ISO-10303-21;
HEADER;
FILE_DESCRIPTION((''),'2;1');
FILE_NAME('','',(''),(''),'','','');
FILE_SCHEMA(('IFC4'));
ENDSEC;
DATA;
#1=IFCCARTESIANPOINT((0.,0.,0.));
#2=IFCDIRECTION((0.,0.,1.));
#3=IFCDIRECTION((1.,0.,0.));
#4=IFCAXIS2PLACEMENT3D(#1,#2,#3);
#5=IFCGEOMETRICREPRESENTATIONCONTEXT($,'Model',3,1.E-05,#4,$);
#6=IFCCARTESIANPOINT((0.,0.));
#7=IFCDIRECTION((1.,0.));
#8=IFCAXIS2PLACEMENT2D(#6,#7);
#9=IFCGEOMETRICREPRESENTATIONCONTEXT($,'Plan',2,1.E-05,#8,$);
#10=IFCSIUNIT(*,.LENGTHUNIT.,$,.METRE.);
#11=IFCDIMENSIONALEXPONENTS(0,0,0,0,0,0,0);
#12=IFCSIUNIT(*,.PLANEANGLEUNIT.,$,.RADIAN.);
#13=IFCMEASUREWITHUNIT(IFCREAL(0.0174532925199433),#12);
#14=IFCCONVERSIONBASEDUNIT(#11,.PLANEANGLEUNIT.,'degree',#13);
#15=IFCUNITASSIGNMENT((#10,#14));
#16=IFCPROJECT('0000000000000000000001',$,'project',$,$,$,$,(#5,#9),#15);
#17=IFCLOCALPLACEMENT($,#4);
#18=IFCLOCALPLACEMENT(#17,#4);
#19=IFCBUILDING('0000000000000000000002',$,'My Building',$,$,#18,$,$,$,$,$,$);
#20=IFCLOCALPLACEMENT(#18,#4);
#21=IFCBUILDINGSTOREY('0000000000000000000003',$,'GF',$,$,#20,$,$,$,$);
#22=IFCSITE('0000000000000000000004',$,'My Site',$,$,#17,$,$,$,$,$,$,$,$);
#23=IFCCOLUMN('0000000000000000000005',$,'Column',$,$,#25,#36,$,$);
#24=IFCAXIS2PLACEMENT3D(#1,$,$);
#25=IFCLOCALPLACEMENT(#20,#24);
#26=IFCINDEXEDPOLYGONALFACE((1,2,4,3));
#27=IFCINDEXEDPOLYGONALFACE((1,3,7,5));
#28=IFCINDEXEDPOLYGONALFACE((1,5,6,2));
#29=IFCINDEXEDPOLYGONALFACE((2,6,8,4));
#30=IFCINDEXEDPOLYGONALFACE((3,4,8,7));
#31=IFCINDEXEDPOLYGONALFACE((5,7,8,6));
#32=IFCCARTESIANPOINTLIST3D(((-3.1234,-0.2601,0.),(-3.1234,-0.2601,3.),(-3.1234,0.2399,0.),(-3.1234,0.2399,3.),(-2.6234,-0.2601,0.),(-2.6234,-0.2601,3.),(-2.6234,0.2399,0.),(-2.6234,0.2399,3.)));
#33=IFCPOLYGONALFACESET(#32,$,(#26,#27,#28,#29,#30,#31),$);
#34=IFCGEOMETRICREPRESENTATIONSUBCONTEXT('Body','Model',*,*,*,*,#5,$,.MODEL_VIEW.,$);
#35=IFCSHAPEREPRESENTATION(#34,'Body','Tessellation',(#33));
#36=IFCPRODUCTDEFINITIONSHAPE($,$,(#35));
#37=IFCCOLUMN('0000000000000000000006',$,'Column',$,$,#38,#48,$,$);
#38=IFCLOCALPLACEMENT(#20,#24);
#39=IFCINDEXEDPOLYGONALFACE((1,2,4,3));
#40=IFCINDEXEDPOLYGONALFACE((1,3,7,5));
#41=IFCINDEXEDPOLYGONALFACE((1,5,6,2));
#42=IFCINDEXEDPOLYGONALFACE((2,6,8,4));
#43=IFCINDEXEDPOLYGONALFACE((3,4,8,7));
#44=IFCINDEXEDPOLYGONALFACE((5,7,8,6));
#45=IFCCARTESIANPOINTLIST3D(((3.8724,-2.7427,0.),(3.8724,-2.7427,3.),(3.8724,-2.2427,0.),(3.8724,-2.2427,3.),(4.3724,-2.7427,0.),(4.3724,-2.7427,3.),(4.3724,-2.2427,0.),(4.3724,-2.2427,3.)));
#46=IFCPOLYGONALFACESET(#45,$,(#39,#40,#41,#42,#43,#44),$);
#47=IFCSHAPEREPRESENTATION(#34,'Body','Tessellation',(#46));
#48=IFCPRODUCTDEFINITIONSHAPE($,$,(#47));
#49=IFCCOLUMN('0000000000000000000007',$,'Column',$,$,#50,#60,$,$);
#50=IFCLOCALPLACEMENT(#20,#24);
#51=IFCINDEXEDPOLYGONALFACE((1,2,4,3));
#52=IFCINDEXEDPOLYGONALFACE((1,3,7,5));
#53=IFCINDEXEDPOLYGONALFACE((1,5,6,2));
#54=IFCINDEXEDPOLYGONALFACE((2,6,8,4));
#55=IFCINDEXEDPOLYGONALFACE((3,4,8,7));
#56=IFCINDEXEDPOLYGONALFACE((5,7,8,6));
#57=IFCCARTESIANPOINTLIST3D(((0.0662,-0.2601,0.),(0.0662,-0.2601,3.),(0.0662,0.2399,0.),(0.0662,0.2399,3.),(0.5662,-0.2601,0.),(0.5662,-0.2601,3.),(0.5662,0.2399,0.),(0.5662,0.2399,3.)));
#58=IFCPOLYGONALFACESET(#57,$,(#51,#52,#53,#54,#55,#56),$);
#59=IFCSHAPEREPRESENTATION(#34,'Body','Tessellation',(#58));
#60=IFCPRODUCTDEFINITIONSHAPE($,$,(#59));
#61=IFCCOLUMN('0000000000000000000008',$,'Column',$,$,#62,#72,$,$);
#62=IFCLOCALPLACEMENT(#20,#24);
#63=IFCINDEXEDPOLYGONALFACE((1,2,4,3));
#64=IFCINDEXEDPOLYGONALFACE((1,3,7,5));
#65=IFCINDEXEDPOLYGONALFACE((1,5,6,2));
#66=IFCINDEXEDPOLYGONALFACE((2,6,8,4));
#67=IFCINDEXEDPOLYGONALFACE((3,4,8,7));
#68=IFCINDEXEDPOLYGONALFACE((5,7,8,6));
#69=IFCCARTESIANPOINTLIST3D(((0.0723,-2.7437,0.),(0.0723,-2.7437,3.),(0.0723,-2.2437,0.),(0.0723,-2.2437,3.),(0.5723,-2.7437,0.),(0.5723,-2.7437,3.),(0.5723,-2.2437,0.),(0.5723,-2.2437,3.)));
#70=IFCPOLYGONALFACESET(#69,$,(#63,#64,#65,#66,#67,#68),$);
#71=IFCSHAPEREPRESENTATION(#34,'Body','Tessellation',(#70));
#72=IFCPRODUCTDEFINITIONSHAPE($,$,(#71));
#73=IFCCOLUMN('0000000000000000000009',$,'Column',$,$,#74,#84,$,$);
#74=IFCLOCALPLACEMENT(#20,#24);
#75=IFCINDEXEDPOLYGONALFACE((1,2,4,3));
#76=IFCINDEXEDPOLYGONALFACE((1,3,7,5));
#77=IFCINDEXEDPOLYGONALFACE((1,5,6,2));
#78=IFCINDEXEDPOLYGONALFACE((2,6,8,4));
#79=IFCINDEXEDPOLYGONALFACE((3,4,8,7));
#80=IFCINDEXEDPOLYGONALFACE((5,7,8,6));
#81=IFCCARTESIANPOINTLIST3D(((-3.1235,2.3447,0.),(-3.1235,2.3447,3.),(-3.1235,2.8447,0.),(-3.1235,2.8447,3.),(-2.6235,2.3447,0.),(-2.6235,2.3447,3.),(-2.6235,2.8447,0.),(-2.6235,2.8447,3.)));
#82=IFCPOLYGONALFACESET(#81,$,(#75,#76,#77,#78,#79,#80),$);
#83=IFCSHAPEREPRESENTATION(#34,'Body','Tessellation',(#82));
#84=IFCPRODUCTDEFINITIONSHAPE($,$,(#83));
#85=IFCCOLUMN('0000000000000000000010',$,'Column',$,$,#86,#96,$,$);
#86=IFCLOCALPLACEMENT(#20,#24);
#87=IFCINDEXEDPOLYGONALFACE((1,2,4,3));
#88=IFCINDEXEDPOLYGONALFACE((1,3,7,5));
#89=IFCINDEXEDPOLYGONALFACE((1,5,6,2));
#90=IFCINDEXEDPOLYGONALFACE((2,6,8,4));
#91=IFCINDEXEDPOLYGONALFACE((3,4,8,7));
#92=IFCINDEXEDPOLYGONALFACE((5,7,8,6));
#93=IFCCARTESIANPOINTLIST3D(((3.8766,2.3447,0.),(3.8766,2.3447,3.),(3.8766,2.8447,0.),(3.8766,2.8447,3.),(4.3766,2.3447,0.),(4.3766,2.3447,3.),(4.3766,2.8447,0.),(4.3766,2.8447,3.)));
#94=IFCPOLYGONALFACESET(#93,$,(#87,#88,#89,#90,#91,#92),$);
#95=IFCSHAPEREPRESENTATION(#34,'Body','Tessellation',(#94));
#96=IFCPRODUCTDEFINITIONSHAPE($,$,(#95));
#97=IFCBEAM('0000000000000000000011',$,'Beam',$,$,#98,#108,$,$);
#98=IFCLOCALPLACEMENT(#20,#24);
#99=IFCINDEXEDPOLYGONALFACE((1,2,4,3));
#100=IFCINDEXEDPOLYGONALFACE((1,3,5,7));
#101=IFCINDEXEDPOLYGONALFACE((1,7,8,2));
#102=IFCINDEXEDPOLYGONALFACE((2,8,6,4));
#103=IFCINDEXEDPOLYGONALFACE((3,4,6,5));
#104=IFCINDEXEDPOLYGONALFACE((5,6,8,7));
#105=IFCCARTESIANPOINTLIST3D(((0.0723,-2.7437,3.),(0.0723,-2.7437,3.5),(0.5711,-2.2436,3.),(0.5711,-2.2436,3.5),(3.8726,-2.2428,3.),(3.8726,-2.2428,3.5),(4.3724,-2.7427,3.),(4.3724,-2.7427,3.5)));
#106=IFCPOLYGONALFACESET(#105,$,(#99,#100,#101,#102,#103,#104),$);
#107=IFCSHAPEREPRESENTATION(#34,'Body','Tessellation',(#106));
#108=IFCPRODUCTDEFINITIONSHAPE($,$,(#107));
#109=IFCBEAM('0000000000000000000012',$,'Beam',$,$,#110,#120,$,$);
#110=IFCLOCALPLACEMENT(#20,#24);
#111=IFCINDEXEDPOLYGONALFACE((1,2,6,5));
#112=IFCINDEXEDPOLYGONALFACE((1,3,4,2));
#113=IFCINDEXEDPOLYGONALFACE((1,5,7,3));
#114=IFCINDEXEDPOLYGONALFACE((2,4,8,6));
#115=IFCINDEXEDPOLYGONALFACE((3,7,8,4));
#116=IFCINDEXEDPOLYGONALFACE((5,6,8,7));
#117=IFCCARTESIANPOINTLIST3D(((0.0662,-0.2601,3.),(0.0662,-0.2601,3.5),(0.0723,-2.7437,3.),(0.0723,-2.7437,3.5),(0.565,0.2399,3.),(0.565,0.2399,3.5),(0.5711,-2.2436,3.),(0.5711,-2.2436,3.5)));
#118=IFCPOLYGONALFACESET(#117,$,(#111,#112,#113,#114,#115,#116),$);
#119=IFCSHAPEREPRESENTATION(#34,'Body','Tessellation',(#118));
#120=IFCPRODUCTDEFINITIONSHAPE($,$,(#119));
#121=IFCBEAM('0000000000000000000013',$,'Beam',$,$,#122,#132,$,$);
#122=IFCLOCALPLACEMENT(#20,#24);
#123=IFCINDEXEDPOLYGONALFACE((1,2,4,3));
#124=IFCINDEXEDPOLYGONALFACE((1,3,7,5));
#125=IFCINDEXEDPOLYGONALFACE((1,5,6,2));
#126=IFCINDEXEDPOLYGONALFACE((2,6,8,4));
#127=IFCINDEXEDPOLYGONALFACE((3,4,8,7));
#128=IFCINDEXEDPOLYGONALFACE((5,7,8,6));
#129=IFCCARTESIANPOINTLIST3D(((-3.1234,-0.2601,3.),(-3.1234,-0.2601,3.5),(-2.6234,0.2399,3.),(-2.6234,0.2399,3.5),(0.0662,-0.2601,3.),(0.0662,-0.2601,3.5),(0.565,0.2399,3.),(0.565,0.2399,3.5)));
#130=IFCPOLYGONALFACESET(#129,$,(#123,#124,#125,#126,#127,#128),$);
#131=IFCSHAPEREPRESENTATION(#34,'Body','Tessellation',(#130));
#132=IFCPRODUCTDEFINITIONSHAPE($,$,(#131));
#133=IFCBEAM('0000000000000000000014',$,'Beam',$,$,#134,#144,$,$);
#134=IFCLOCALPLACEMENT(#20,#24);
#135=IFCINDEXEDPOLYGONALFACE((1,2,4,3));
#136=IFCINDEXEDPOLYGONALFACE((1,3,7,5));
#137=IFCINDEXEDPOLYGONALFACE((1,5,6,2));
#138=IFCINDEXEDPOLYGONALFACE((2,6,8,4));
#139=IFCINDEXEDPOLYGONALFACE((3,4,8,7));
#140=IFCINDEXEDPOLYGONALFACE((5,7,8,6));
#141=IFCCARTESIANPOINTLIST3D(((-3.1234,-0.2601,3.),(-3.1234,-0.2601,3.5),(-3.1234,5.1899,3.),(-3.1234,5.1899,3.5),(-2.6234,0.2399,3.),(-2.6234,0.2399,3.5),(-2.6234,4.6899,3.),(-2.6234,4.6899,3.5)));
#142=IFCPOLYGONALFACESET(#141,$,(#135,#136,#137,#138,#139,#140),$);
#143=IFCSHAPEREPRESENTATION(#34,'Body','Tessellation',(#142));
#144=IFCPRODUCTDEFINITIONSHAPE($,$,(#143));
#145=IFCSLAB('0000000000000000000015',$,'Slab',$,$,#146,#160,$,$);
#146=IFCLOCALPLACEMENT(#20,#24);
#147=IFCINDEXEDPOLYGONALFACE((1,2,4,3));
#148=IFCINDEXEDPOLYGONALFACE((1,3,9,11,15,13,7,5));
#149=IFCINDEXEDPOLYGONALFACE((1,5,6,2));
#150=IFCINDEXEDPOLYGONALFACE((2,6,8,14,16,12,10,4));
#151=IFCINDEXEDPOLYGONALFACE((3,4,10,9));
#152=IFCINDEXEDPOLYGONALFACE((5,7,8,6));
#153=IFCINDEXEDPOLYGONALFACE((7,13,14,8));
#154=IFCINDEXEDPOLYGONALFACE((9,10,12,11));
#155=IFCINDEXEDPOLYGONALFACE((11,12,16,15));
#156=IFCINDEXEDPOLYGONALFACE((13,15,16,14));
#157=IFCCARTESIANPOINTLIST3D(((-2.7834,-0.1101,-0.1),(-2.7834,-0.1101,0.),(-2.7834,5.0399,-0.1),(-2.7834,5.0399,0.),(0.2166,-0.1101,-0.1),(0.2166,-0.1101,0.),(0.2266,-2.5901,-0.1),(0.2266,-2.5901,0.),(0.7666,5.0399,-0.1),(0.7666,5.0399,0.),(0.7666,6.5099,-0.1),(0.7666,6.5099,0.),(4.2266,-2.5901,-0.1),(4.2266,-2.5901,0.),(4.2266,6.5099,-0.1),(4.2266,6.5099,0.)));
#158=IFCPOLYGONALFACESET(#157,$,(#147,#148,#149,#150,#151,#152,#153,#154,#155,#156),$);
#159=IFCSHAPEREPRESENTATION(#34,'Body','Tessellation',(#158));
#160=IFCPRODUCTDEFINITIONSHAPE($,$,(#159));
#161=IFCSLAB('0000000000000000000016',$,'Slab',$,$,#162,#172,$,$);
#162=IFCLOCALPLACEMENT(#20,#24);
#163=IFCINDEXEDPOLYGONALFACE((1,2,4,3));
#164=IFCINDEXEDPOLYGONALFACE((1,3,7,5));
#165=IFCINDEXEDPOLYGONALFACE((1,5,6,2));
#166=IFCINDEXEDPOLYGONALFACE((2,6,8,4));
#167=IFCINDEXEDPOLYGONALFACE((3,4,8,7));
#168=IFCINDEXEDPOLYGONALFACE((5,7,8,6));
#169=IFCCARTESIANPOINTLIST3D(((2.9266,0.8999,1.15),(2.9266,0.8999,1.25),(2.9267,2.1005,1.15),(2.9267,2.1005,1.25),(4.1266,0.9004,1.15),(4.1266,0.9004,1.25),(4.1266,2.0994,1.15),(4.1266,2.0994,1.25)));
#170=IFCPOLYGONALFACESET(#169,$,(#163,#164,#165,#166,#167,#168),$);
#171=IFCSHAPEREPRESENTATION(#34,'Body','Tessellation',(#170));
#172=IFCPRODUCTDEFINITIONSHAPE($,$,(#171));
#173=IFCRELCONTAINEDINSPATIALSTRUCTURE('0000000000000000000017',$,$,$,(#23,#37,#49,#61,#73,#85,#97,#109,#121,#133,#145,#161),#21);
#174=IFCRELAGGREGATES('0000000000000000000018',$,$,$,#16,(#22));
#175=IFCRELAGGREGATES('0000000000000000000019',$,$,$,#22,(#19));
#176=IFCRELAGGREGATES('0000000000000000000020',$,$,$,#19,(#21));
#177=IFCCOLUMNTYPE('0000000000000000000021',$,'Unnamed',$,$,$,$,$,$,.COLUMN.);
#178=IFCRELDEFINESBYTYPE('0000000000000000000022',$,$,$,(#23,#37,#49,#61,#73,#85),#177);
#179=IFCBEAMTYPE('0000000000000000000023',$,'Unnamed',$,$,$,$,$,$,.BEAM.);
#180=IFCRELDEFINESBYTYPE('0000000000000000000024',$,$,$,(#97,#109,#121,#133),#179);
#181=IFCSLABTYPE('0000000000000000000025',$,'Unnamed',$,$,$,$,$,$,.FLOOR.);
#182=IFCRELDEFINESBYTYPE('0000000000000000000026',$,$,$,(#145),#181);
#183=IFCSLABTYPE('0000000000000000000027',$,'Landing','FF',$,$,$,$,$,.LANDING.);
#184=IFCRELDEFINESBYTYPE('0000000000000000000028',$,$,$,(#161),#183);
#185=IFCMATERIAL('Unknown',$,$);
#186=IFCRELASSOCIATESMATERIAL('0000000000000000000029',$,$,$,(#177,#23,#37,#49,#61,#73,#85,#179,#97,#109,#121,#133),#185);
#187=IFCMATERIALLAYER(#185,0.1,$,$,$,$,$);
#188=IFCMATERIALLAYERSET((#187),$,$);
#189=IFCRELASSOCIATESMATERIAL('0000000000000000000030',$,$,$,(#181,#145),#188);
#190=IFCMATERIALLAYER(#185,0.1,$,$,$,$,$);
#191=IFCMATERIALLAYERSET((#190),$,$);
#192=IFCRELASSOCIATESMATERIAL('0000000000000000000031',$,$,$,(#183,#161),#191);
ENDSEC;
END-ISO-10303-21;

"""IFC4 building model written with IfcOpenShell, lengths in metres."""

from ifc_helpers import new_model, entity, si_unit, converted_unit, frame, origin_with_axes, origin_2d_with_axis, place, context, subcontext, project, spatial, indexed_curve, rectangle, outline, extrude, clip, halfspace, material, layer, layer_set, layer_usage, material_profile, profile_set, profile_usage, type_object, element, save


model = new_model("IFC4")

# Units and contexts
model_context = context("Model", 3, precision=1e-05, world=origin_with_axes())
plan_context = context("Plan", 2, precision=1e-05, world=origin_2d_with_axis())
body_context_1 = subcontext(model_context, "Body", "Model", "MODEL_VIEW")
ifc_project = project(units=[si_unit("LENGTHUNIT", "METRE"), converted_unit("PLANEANGLEUNIT", "degree", entity("IfcReal", 0.0174532925199433), si_unit("PLANEANGLEUNIT", "RADIAN"), dimensions=[0, 0, 0, 0, 0, 0, 0])], contexts=[model_context, plan_context])

# Site, building, storey
site_placement = place(None, origin_with_axes())
site = spatial("IfcSite", under=ifc_project, at=site_placement, Name="My Site")
building_placement = place(site_placement, origin_with_axes())
building = spatial("IfcBuilding", under=site, at=building_placement, Name="My Building")
storey_placement = place(building_placement, origin_with_axes())
storey = spatial("IfcBuildingStorey", under=building, at=storey_placement, Name="GF")

# Columns
ifc_material_1 = material(Name="Unknown")
ifc_material_profile_1 = material_profile(ifc_material_1, rectangle(XDim=0.5, YDim=0.5))
ifc_profile_set_1 = profile_set([ifc_material_profile_1])
ifc_profile_usage_1 = profile_usage(ifc_profile_set_1, cardinal=5)
column_type = type_object("IfcColumnType", Name="Unnamed", PredefinedType="COLUMN", material=ifc_profile_set_1)
column_1_placement = place(storey_placement, frame((-2.8734, -0.0101, 0.0), z_axis=(0.0, 0.0, 1.0), x_axis=(1.0, 0.0, 0.0)))
element("IfcColumn", 1, at=column_1_placement, inside=storey, type_object=column_type, material=ifc_profile_usage_1, Name="Column", context=body_context_1, shape_type="SweptSolid", body=[
    extrude(rectangle(XDim=0.5, YDim=0.5), origin_with_axes(), (0.0, 0.0, 1.0), 3.0),
])
ifc_profile_usage_2 = profile_usage(ifc_profile_set_1, cardinal=5)
column_2_placement = place(storey_placement, frame((4.1224, -2.4927, 0.0), z_axis=(0.0, 0.0, 1.0), x_axis=(1.0, 0.0, 0.0)))
element("IfcColumn", 2, at=column_2_placement, inside=storey, type_object=column_type, material=ifc_profile_usage_2, Name="Column", context=body_context_1, shape_type="SweptSolid", body=[
    extrude(rectangle(XDim=0.5, YDim=0.5), origin_with_axes(), (0.0, 0.0, 1.0), 3.0),
])
ifc_profile_usage_3 = profile_usage(ifc_profile_set_1, cardinal=5)
column_3_placement = place(storey_placement, frame((0.3162, -0.0101, 0.0), z_axis=(0.0, 0.0, 1.0), x_axis=(1.0, 0.0, 0.0)))
element("IfcColumn", 3, at=column_3_placement, inside=storey, type_object=column_type, material=ifc_profile_usage_3, Name="Column", context=body_context_1, shape_type="SweptSolid", body=[
    extrude(rectangle(XDim=0.5, YDim=0.5), origin_with_axes(), (0.0, 0.0, 1.0), 3.0),
])
ifc_profile_usage_4 = profile_usage(ifc_profile_set_1, cardinal=5)
column_4_placement = place(storey_placement, frame((0.3223, -2.4937, 0.0), z_axis=(0.0, 0.0, 1.0), x_axis=(1.0, 0.0, 0.0)))
element("IfcColumn", 4, at=column_4_placement, inside=storey, type_object=column_type, material=ifc_profile_usage_4, Name="Column", context=body_context_1, shape_type="SweptSolid", body=[
    extrude(rectangle(XDim=0.5, YDim=0.5), origin_with_axes(), (0.0, 0.0, 1.0), 3.0),
])
ifc_profile_usage_5 = profile_usage(ifc_profile_set_1, cardinal=5)
column_5_placement = place(storey_placement, frame((-2.8735, 2.5947, 0.0), z_axis=(0.0, 0.0, 1.0), x_axis=(1.0, 0.0, 0.0)))
element("IfcColumn", 5, at=column_5_placement, inside=storey, type_object=column_type, material=ifc_profile_usage_5, Name="Column", context=body_context_1, shape_type="SweptSolid", body=[
    extrude(rectangle(XDim=0.5, YDim=0.5), origin_with_axes(), (0.0, 0.0, 1.0), 3.0),
])
ifc_profile_usage_6 = profile_usage(ifc_profile_set_1, cardinal=5)
column_6_placement = place(storey_placement, frame((4.1266, 2.5947, 0.0), z_axis=(0.0, 0.0, 1.0), x_axis=(1.0, 0.0, 0.0)))
element("IfcColumn", 6, at=column_6_placement, inside=storey, type_object=column_type, material=ifc_profile_usage_6, Name="Column", context=body_context_1, shape_type="SweptSolid", body=[
    extrude(rectangle(XDim=0.5, YDim=0.5), origin_with_axes(), (0.0, 0.0, 1.0), 3.0),
])

# Beams
ifc_material_profile_2 = material_profile(ifc_material_1, rectangle(XDim=0.5, YDim=0.5))
ifc_profile_set_2 = profile_set([ifc_material_profile_2])
ifc_profile_usage_7 = profile_usage(ifc_profile_set_2, cardinal=1)
beam_type = type_object("IfcBeamType", Name="Unnamed", PredefinedType="BEAM", material=ifc_profile_set_2)
beam_1_placement = place(storey_placement, frame((4.8724, -2.7426, 3.0), z_axis=(-1.0, -0.000231, 0.0), x_axis=(0.000231, -1.0, 0.0)))
element("IfcBeam", 7, at=beam_1_placement, inside=storey, type_object=beam_type, material=ifc_profile_usage_7, Name="Beam", context=body_context_1, shape_type="Clipping", body=[
    clip(clip(extrude(rectangle(XDim=0.5, YDim=0.5), frame((-0.25, 0.25, 0.0), z_axis=(0.0, 0.0, 1.0), x_axis=(1.0, 0.0, 0.0)), (0.0, 0.0, 1.0), 5.3001), halfspace(frame((0.0, -3.0, 4.8001), z_axis=(-0.706313, 0.0, 0.707899), x_axis=(0.0, 1.0, 0.0)), False)), halfspace(frame((0.0, -3.0, 0.5), z_axis=(-0.706867, 0.0, -0.707346), x_axis=(0.0, 1.0, 0.0)), False)),
])
ifc_profile_usage_8 = profile_usage(ifc_profile_set_2, cardinal=1)
beam_2_placement = place(storey_placement, frame((0.0736, -3.2437, 3.0), z_axis=(-0.002474, 0.999997, 0.0), x_axis=(-0.999997, -0.002474, 0.0)))
element("IfcBeam", 8, at=beam_2_placement, inside=storey, type_object=beam_type, material=ifc_profile_usage_8, Name="Beam", context=body_context_1, shape_type="Clipping", body=[
    clip(clip(extrude(rectangle(XDim=0.5, YDim=0.5), frame((-0.25, 0.25, 0.0), z_axis=(0.0, 0.0, 1.0), x_axis=(1.0, 0.0, 0.0)), (0.0, 0.0, 1.0), 3.9836), halfspace(frame((-0.5, -3.0, 3.4824), z_axis=(0.706232, 0.0, 0.707981), x_axis=(0.0, -1.0, 0.0)), False)), halfspace(frame((0.0, -3.0, 0.5), z_axis=(-0.706314, 0.0, -0.707899), x_axis=(0.0, 1.0, 0.0)), False)),
])
ifc_profile_usage_9 = profile_usage(ifc_profile_set_2, cardinal=1)
beam_3_placement = place(storey_placement, frame((1.0662, -0.2601, 3.0), z_axis=(-1.0, 0.0, 0.0), x_axis=(0.0, -1.0, 0.0)))
element("IfcBeam", 9, at=beam_3_placement, inside=storey, type_object=beam_type, material=ifc_profile_usage_9, Name="Beam", context=body_context_1, shape_type="Clipping", body=[
    clip(clip(extrude(rectangle(XDim=0.5, YDim=0.5), frame((-0.25, 0.25, 0.0), z_axis=(0.0, 0.0, 1.0), x_axis=(1.0, 0.0, 0.0)), (0.0, 0.0, 1.0), 4.1896), halfspace(frame((0.0, -3.0, 4.1896), z_axis=(-0.707107, 0.0, 0.707107), x_axis=(0.0, 1.0, 0.0)), False)), halfspace(frame((-0.5, -3.0, 0.5012), z_axis=(0.706232, 0.0, -0.707981), x_axis=(0.0, -1.0, 0.0)), False)),
])
ifc_profile_usage_10 = profile_usage(ifc_profile_set_2, cardinal=1)
beam_4_placement = place(storey_placement, frame((-3.1234, -0.2601, 3.0), z_axis=(0.0, 1.0, 0.0), x_axis=(-1.0, 0.0, 0.0)))
element("IfcBeam", 10, at=beam_4_placement, inside=storey, type_object=beam_type, material=ifc_profile_usage_10, Name="Beam", context=body_context_1, shape_type="Clipping", body=[
    clip(clip(extrude(rectangle(XDim=0.5, YDim=0.5), frame((-0.25, 0.25, 0.0), z_axis=(0.0, 0.0, 1.0), x_axis=(1.0, 0.0, 0.0)), (0.0, 0.0, 1.0), 5.45), halfspace(frame((0.0, -3.0, 5.45), z_axis=(-0.707107, 0.0, 0.707107), x_axis=(0.0, 1.0, 0.0)), False)), halfspace(frame((0.0, -3.0, 0.0), z_axis=(-0.707107, 0.0, -0.707107), x_axis=(0.0, 1.0, 0.0)), False)),
])

# Slabs
ifc_layer_1 = layer(ifc_material_1, 0.1)
ifc_layer_set_1 = layer_set([ifc_layer_1])
ifc_layer_usage_1 = layer_usage(ifc_layer_set_1, "AXIS3", "POSITIVE", -0.1)
slab_type_1 = type_object("IfcSlabType", Name="Unnamed", PredefinedType="FLOOR", material=ifc_layer_set_1)
slab_1_placement = place(storey_placement, frame((4.2266, -2.5901, 0.0), z_axis=(0.0, 0.0, 1.0), x_axis=(1.0, 0.0, 0.0)))
element("IfcSlab", 11, at=slab_1_placement, inside=storey, type_object=slab_type_1, material=ifc_layer_usage_1, Name="Slab", context=body_context_1, shape_type="SweptSolid", body=[
    extrude(outline(indexed_curve([(0.0, 0.0), (0.0, 9.1), (-3.46, 9.1), (-3.46, 7.63), (-7.01, 7.63), (-7.01, 2.48), (-4.01, 2.48), (-4.0, 0.0), (0.0, 0.0)])), frame((0.0, 0.0, -0.1), z_axis=(0.0, 0.0, 1.0), x_axis=(1.0, 0.0, 0.0)), (0.0, 0.0, 1.0), 0.1),
])
ifc_layer_2 = layer(ifc_material_1, 0.1)
ifc_layer_set_2 = layer_set([ifc_layer_2])
ifc_layer_usage_2 = layer_usage(ifc_layer_set_2, "AXIS3", "POSITIVE", -0.1)
slab_type_2 = type_object("IfcSlabType", Name="Landing", Description="FF", PredefinedType="LANDING", material=ifc_layer_set_2)
slab_2_placement = place(storey_placement, frame((2.9266, 0.8999, 1.25), z_axis=(0.0, 0.0, 1.0), x_axis=(1.0, 0.0, 0.0)))
element("IfcSlab", 12, at=slab_2_placement, inside=storey, type_object=slab_type_2, material=ifc_layer_usage_2, Name="Slab", context=body_context_1, shape_type="SweptSolid", body=[
    extrude(outline(indexed_curve([(0.0, 0.0), (1.2, 0.0005), (1.2, 1.1995), (0.0001, 1.2006), (0.0, 0.0)])), frame((0.0, 0.0, -0.1), z_axis=(0.0, 0.0, 1.0), x_axis=(1.0, 0.0, 0.0)), (0.0, 0.0, 1.0), 0.1),
])

save(model, "model.ifc")
